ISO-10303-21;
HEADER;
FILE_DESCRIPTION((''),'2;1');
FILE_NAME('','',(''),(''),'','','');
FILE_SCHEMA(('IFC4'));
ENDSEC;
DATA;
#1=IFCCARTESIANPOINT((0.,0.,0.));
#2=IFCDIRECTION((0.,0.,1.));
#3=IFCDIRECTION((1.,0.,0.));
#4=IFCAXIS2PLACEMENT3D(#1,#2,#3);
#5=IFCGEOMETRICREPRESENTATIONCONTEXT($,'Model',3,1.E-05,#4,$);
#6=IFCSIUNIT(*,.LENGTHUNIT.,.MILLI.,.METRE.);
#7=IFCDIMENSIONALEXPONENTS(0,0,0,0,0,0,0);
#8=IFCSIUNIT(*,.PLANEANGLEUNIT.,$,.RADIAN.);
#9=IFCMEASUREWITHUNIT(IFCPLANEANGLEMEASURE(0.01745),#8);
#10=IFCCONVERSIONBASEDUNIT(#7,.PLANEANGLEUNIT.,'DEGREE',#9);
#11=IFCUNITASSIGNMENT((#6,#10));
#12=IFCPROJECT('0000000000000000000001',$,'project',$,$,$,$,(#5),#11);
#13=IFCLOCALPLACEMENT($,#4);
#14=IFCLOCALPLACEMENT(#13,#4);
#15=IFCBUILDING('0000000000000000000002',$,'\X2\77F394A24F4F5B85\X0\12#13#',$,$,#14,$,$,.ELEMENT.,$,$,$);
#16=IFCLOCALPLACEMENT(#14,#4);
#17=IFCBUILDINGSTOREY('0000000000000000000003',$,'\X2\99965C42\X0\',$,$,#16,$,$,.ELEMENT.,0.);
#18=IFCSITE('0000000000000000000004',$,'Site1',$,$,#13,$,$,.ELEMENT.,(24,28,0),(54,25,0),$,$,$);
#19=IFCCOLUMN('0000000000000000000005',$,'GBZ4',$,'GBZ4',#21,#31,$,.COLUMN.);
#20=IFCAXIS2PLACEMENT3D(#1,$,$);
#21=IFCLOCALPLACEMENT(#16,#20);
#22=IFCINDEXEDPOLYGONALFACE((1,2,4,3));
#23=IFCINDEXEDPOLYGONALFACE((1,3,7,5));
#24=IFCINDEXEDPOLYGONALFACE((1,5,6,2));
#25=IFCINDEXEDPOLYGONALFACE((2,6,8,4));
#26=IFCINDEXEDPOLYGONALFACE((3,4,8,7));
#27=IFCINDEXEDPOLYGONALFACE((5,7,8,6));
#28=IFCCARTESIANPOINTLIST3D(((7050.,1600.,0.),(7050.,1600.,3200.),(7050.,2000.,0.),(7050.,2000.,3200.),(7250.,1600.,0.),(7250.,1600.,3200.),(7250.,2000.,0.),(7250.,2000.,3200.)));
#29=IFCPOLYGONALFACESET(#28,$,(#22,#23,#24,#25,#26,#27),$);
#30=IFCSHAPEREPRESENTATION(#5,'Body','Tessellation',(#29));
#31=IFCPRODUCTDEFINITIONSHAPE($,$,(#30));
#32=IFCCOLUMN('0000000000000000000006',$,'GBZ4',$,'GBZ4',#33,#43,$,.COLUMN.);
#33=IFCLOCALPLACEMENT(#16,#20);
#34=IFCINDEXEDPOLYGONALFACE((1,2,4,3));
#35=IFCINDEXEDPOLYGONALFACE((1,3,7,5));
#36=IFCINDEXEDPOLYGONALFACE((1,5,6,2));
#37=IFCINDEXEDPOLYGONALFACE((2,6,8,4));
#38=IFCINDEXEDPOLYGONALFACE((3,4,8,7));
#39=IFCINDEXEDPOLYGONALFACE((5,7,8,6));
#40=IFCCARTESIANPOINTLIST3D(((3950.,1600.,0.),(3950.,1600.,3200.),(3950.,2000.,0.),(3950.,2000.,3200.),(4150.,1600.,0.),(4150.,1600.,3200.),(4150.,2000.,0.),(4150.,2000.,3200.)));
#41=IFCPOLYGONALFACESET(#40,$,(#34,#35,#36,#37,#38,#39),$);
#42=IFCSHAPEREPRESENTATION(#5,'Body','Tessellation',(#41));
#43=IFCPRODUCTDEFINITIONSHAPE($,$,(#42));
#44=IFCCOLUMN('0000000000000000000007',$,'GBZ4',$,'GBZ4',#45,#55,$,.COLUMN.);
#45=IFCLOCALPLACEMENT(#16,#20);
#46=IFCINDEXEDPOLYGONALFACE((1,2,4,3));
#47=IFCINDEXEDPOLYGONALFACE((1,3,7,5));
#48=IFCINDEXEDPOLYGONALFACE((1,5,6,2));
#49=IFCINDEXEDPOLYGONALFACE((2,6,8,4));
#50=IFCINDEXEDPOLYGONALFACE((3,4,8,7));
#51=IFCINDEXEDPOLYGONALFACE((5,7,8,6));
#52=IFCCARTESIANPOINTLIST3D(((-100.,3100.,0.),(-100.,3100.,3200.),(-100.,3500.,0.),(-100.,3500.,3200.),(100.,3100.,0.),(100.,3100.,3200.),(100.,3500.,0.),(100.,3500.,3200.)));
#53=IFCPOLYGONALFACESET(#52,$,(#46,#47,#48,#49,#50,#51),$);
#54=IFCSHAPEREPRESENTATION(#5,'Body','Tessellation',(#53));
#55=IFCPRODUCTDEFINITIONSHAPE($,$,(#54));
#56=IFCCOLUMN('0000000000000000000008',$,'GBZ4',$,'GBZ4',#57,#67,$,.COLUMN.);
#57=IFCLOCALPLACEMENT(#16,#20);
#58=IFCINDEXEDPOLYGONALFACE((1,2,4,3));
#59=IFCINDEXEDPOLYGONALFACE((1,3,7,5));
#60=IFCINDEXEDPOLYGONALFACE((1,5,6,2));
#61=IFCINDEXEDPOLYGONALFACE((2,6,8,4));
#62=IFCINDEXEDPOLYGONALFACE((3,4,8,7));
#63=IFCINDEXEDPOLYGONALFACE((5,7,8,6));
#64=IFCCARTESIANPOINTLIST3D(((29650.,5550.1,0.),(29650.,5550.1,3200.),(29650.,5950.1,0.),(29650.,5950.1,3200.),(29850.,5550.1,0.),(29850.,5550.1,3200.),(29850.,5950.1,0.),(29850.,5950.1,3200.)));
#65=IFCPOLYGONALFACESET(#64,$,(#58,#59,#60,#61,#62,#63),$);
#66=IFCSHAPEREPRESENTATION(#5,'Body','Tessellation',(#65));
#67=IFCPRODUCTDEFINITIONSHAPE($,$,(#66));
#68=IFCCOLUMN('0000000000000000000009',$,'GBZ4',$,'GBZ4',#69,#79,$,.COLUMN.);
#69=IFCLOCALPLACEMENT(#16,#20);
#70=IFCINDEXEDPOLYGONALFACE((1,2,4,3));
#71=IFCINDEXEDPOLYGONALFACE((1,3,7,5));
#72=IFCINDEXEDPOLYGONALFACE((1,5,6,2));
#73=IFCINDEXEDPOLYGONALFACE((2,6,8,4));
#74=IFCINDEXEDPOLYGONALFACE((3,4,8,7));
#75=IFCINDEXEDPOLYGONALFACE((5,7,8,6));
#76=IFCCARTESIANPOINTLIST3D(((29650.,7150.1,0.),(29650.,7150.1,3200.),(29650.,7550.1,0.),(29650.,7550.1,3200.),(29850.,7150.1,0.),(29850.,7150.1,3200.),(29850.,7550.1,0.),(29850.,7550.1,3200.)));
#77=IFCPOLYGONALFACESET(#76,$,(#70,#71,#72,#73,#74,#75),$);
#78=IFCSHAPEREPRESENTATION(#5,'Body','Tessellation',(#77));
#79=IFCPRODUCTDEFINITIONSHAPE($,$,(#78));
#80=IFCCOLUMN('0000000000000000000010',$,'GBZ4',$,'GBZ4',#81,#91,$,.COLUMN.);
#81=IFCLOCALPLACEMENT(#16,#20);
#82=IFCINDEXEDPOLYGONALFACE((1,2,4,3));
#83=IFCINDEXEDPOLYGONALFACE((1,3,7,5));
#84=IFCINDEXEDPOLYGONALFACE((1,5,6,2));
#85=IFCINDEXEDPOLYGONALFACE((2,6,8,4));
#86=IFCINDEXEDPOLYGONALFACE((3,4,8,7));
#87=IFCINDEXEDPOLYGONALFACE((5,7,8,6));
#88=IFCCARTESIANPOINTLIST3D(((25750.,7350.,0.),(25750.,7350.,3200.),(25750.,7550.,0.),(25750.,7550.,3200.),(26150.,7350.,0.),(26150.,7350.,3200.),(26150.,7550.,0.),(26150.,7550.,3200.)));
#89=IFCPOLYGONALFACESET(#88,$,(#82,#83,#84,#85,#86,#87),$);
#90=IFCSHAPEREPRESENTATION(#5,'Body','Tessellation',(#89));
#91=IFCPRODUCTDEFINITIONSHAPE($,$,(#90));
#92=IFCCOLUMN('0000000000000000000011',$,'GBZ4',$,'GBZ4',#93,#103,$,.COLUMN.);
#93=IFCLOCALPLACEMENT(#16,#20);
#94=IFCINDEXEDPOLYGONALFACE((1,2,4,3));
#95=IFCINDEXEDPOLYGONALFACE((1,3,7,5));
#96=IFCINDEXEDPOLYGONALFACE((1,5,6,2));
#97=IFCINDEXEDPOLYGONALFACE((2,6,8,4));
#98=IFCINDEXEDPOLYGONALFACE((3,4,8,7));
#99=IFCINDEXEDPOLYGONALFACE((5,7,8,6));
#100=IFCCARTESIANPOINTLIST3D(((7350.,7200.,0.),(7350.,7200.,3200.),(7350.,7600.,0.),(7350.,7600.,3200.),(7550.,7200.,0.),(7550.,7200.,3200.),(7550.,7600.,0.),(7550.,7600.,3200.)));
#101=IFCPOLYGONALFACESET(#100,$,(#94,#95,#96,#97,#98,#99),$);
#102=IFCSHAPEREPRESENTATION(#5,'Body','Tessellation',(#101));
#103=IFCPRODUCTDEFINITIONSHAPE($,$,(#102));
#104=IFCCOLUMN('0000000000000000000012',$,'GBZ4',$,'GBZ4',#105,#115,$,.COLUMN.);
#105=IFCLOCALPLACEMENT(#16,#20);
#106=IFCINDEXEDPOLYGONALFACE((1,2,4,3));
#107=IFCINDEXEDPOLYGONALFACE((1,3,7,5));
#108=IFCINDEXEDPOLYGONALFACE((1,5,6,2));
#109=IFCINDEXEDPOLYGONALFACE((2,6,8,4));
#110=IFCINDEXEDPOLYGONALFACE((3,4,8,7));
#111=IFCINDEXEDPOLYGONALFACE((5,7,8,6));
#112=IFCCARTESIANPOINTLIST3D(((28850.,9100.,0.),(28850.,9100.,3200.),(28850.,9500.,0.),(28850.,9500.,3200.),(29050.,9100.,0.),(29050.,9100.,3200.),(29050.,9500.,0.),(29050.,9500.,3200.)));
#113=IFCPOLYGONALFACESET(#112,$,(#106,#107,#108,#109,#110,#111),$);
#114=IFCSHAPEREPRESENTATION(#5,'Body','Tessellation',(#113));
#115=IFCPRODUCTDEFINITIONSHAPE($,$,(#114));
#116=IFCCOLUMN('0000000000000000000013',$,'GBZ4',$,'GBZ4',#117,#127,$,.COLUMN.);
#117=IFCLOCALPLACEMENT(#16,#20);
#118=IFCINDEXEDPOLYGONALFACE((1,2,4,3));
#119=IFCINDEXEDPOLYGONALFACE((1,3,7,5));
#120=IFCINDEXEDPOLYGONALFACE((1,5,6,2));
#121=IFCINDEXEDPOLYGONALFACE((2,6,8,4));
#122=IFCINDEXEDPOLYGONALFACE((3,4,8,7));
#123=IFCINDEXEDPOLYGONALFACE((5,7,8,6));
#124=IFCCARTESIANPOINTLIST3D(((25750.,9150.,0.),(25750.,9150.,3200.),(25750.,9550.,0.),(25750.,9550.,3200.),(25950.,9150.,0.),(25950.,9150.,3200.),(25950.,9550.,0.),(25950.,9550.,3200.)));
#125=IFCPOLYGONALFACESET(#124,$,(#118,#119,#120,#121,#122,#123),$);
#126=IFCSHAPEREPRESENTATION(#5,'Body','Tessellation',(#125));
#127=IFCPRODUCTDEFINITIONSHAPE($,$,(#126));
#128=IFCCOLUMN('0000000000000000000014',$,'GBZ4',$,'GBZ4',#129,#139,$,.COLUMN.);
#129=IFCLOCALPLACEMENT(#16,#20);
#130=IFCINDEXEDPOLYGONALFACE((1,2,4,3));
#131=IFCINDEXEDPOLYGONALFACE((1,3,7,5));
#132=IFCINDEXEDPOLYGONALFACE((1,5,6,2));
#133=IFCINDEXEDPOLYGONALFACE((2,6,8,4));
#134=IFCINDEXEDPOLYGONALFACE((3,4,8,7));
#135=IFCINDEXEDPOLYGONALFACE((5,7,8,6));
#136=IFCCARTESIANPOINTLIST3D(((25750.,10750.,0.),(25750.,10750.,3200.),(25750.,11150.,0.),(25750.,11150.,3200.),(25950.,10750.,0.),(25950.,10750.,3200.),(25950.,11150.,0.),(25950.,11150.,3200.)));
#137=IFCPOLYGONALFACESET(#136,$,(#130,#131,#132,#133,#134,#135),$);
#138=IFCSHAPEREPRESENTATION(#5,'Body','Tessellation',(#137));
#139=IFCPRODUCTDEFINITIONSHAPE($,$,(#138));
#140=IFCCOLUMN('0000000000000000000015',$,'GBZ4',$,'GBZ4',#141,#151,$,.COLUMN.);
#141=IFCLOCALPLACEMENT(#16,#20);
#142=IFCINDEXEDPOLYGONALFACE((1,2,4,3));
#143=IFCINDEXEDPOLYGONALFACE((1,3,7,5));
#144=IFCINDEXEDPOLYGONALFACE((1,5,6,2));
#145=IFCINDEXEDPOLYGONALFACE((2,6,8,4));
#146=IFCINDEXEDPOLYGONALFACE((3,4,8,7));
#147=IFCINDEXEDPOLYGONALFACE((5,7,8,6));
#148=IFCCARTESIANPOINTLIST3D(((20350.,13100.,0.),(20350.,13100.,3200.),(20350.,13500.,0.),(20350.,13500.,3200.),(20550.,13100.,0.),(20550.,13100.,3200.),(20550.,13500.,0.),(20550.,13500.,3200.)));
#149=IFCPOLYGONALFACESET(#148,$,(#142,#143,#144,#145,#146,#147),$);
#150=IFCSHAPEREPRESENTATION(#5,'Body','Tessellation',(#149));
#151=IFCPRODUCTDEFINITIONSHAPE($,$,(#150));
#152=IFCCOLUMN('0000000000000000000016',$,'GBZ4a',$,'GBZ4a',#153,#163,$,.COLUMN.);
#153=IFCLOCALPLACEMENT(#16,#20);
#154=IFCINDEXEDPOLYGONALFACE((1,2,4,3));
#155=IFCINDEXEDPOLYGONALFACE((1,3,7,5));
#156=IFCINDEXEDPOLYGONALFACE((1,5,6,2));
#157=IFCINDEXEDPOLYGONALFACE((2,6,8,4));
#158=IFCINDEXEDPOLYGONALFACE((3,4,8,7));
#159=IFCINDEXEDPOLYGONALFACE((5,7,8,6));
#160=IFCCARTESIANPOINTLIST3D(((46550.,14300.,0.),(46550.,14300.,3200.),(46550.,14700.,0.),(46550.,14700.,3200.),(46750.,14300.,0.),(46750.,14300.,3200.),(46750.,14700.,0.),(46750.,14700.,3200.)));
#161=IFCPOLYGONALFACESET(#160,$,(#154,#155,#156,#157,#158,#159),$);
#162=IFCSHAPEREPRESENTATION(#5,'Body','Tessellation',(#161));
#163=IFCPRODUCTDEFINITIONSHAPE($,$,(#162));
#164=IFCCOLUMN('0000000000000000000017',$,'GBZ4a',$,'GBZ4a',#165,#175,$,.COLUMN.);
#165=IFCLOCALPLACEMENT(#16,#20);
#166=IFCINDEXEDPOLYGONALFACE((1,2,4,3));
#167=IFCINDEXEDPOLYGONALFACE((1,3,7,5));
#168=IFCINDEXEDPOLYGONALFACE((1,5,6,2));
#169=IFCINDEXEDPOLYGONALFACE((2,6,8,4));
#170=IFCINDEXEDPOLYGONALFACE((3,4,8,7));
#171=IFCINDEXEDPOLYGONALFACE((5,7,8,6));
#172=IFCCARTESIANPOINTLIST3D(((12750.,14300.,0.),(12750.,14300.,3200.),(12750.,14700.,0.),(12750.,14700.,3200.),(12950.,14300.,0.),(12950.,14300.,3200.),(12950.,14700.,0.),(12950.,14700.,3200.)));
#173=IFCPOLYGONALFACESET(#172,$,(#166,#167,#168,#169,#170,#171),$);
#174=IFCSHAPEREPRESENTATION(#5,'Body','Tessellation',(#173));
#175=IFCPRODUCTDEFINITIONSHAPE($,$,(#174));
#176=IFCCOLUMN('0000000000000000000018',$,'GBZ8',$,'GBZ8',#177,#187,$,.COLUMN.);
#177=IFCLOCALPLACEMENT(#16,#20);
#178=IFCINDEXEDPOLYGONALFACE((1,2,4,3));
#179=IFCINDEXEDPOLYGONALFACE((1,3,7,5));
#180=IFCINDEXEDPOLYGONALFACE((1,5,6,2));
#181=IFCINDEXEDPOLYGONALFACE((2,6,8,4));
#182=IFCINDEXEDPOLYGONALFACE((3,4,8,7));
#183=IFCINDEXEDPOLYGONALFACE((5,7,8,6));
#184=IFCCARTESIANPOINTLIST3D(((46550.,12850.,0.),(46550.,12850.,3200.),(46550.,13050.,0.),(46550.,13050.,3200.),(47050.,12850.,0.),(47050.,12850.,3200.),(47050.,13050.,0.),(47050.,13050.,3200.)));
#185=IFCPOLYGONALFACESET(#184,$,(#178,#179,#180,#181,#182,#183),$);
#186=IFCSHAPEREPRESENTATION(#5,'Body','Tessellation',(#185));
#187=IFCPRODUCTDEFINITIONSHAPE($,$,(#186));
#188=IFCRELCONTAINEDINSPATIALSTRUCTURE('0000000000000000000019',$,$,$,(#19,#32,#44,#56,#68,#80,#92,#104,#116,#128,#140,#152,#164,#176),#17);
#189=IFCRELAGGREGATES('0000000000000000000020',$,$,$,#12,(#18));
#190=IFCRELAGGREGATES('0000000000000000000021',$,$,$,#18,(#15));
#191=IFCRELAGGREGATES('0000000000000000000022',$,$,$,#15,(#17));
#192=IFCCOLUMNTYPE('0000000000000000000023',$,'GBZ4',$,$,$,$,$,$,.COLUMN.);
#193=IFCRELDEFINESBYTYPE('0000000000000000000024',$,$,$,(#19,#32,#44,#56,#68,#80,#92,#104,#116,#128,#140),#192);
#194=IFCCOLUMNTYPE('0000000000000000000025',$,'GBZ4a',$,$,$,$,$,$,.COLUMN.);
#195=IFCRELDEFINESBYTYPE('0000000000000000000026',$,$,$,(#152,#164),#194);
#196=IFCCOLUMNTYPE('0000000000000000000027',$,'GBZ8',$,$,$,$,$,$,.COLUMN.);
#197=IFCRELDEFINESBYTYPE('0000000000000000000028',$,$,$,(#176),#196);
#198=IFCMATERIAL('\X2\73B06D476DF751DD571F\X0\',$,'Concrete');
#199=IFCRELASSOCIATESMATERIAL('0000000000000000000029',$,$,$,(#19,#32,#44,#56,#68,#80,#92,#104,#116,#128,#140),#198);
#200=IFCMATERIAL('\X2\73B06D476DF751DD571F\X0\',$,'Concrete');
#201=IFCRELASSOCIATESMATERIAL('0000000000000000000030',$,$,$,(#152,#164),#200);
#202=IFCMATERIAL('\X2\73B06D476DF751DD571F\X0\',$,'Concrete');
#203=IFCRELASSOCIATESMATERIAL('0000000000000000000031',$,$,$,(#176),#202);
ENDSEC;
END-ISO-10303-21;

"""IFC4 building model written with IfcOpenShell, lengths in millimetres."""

from ifc_helpers import new_model, entity, si_unit, converted_unit, frame, origin_with_axes, place, context, project, spatial, polyline, outline, extrude, material, type_object, element, save


model = new_model("IFC4")

# Units and contexts
model_context = context("Model", 3, precision=1e-05, world=origin_with_axes())
ifc_project = project(units=[si_unit("LENGTHUNIT", "METRE", prefix="MILLI"), converted_unit("PLANEANGLEUNIT", "DEGREE", entity("IfcPlaneAngleMeasure", 0.01745), si_unit("PLANEANGLEUNIT", "RADIAN"), dimensions=[0, 0, 0, 0, 0, 0, 0])], contexts=[model_context])

# Site, building, storey
site_placement = place(None, origin_with_axes())
site = spatial("IfcSite", under=ifc_project, at=site_placement, Name="Site1", CompositionType="ELEMENT", RefLatitude=(24, 28, 0), RefLongitude=(54, 25, 0))
building_placement = place(site_placement, origin_with_axes())
building = spatial("IfcBuilding", under=site, at=building_placement, Name="石钢住宅12#13#", CompositionType="ELEMENT")
storey_placement = place(building_placement, origin_with_axes())
storey = spatial("IfcBuildingStorey", under=building, at=storey_placement, Name="首层", CompositionType="ELEMENT", Elevation=0.0)

# Columns
ifc_material_1 = material(Name="现浇混凝土", Category="Concrete")
column_type_1 = type_object("IfcColumnType", Name="GBZ4", PredefinedType="COLUMN")
column_1_placement = place(storey_placement, origin_with_axes())
element("IfcColumn", 1, at=column_1_placement, inside=storey, type_object=column_type_1, material=ifc_material_1, Name="GBZ4", ObjectType="GBZ4", PredefinedType="COLUMN", context=model_context, shape_type="SweptSolid", body=[
    extrude(outline(polyline([(0.0, 0.0), (200.0, 0.0), (200.0, 400.0), (0.0, 400.0), (0.0, 0.0)])), frame((7050.0, 1600.0, 0.0), z_axis=(0.0, 0.0, 1.0), x_axis=(1.0, 0.0, 0.0)), (0.0, 0.0, 1.0), 3200.0),
])
column_2_placement = place(storey_placement, origin_with_axes())
element("IfcColumn", 2, at=column_2_placement, inside=storey, type_object=column_type_1, material=ifc_material_1, Name="GBZ4", ObjectType="GBZ4", PredefinedType="COLUMN", context=model_context, shape_type="SweptSolid", body=[
    extrude(outline(polyline([(0.0, 0.0), (200.0, 0.0), (200.0, 400.0), (0.0, 400.0), (0.0, 0.0)])), frame((3950.0, 1600.0, 0.0), z_axis=(0.0, 0.0, 1.0), x_axis=(1.0, 0.0, 0.0)), (0.0, 0.0, 1.0), 3200.0),
])
column_3_placement = place(storey_placement, origin_with_axes())
element("IfcColumn", 3, at=column_3_placement, inside=storey, type_object=column_type_1, material=ifc_material_1, Name="GBZ4", ObjectType="GBZ4", PredefinedType="COLUMN", context=model_context, shape_type="SweptSolid", body=[
    extrude(outline(polyline([(0.0, 0.0), (200.0, 0.0), (200.0, 400.0), (0.0, 400.0), (0.0, 0.0)])), frame((-100.0, 3100.0, 0.0), z_axis=(0.0, 0.0, 1.0), x_axis=(1.0, 0.0, 0.0)), (0.0, 0.0, 1.0), 3200.0),
])
column_4_placement = place(storey_placement, origin_with_axes())
element("IfcColumn", 4, at=column_4_placement, inside=storey, type_object=column_type_1, material=ifc_material_1, Name="GBZ4", ObjectType="GBZ4", PredefinedType="COLUMN", context=model_context, shape_type="SweptSolid", body=[
    extrude(outline(polyline([(0.0, 0.0), (200.0, 0.0), (200.0, 400.0), (0.0, 400.0), (0.0, 0.0)])), frame((29650.0, 5550.1, 0.0), z_axis=(0.0, 0.0, 1.0), x_axis=(1.0, 0.0, 0.0)), (0.0, 0.0, 1.0), 3200.0),
])
column_5_placement = place(storey_placement, origin_with_axes())
element("IfcColumn", 5, at=column_5_placement, inside=storey, type_object=column_type_1, material=ifc_material_1, Name="GBZ4", ObjectType="GBZ4", PredefinedType="COLUMN", context=model_context, shape_type="SweptSolid", body=[
    extrude(outline(polyline([(0.0, 0.0), (200.0, 0.0), (200.0, 400.0), (0.0, 400.0), (0.0, 0.0)])), frame((29650.0, 7150.1, 0.0), z_axis=(0.0, 0.0, 1.0), x_axis=(1.0, 0.0, 0.0)), (0.0, 0.0, 1.0), 3200.0),
])
column_6_placement = place(storey_placement, origin_with_axes())
element("IfcColumn", 6, at=column_6_placement, inside=storey, type_object=column_type_1, material=ifc_material_1, Name="GBZ4", ObjectType="GBZ4", PredefinedType="COLUMN", context=model_context, shape_type="SweptSolid", body=[
    extrude(outline(polyline([(0.0, 0.0), (200.0, 0.0), (200.0, 400.0), (0.0, 400.0), (0.0, 0.0)])), frame((26150.0, 7350.0, 0.0), z_axis=(0.0, 0.0, 1.0), x_axis=(0.0, 1.0, 0.0)), (0.0, 0.0, 1.0), 3200.0),
])
column_7_placement = place(storey_placement, origin_with_axes())
element("IfcColumn", 7, at=column_7_placement, inside=storey, type_object=column_type_1, material=ifc_material_1, Name="GBZ4", ObjectType="GBZ4", PredefinedType="COLUMN", context=model_context, shape_type="SweptSolid", body=[
    extrude(outline(polyline([(0.0, 0.0), (200.0, 0.0), (200.0, 400.0), (0.0, 400.0), (0.0, 0.0)])), frame((7350.0, 7200.0, 0.0), z_axis=(0.0, 0.0, 1.0), x_axis=(1.0, 0.0, 0.0)), (0.0, 0.0, 1.0), 3200.0),
])
column_8_placement = place(storey_placement, origin_with_axes())
element("IfcColumn", 8, at=column_8_placement, inside=storey, type_object=column_type_1, material=ifc_material_1, Name="GBZ4", ObjectType="GBZ4", PredefinedType="COLUMN", context=model_context, shape_type="SweptSolid", body=[
    extrude(outline(polyline([(0.0, 0.0), (200.0, 0.0), (200.0, 400.0), (0.0, 400.0), (0.0, 0.0)])), frame((28850.0, 9100.0, 0.0), z_axis=(0.0, 0.0, 1.0), x_axis=(1.0, 0.0, 0.0)), (0.0, 0.0, 1.0), 3200.0),
])
column_9_placement = place(storey_placement, origin_with_axes())
element("IfcColumn", 9, at=column_9_placement, inside=storey, type_object=column_type_1, material=ifc_material_1, Name="GBZ4", ObjectType="GBZ4", PredefinedType="COLUMN", context=model_context, shape_type="SweptSolid", body=[
    extrude(outline(polyline([(0.0, 0.0), (200.0, 0.0), (200.0, 400.0), (0.0, 400.0), (0.0, 0.0)])), frame((25750.0, 9150.0, 0.0), z_axis=(0.0, 0.0, 1.0), x_axis=(1.0, 0.0, 0.0)), (0.0, 0.0, 1.0), 3200.0),
])
column_10_placement = place(storey_placement, origin_with_axes())
element("IfcColumn", 10, at=column_10_placement, inside=storey, type_object=column_type_1, material=ifc_material_1, Name="GBZ4", ObjectType="GBZ4", PredefinedType="COLUMN", context=model_context, shape_type="SweptSolid", body=[
    extrude(outline(polyline([(0.0, 0.0), (200.0, 0.0), (200.0, 400.0), (0.0, 400.0), (0.0, 0.0)])), frame((25750.0, 10750.0, 0.0), z_axis=(0.0, 0.0, 1.0), x_axis=(1.0, 0.0, 0.0)), (0.0, 0.0, 1.0), 3200.0),
])
column_11_placement = place(storey_placement, origin_with_axes())
element("IfcColumn", 11, at=column_11_placement, inside=storey, type_object=column_type_1, material=ifc_material_1, Name="GBZ4", ObjectType="GBZ4", PredefinedType="COLUMN", context=model_context, shape_type="SweptSolid", body=[
    extrude(outline(polyline([(0.0, 0.0), (200.0, 0.0), (200.0, 400.0), (0.0, 400.0), (0.0, 0.0)])), frame((20350.0, 13100.0, 0.0), z_axis=(0.0, 0.0, 1.0), x_axis=(1.0, 0.0, 0.0)), (0.0, 0.0, 1.0), 3200.0),
])
ifc_material_2 = material(Name="现浇混凝土", Category="Concrete")
column_type_2 = type_object("IfcColumnType", Name="GBZ4a", PredefinedType="COLUMN")
column_12_placement = place(storey_placement, origin_with_axes())
element("IfcColumn", 12, at=column_12_placement, inside=storey, type_object=column_type_2, material=ifc_material_2, Name="GBZ4a", ObjectType="GBZ4a", PredefinedType="COLUMN", context=model_context, shape_type="SweptSolid", body=[
    extrude(outline(polyline([(0.0, 0.0), (400.0, 0.0), (400.0, 200.0), (0.0, 200.0), (0.0, 0.0)])), frame((46750.0, 14300.0, 0.0), z_axis=(0.0, 0.0, 1.0), x_axis=(0.0, 1.0, 0.0)), (0.0, 0.0, 1.0), 3200.0),
])
column_13_placement = place(storey_placement, origin_with_axes())
element("IfcColumn", 13, at=column_13_placement, inside=storey, type_object=column_type_2, material=ifc_material_2, Name="GBZ4a", ObjectType="GBZ4a", PredefinedType="COLUMN", context=model_context, shape_type="SweptSolid", body=[
    extrude(outline(polyline([(0.0, 0.0), (200.0, 0.0), (200.0, 400.0), (0.0, 400.0), (0.0, 0.0)])), frame((12750.0, 14300.0, 0.0), z_axis=(0.0, 0.0, 1.0), x_axis=(1.0, 0.0, 0.0)), (0.0, 0.0, 1.0), 3200.0),
])
ifc_material_3 = material(Name="现浇混凝土", Category="Concrete")
column_type_3 = type_object("IfcColumnType", Name="GBZ8", PredefinedType="COLUMN")
column_14_placement = place(storey_placement, origin_with_axes())
element("IfcColumn", 14, at=column_14_placement, inside=storey, type_object=column_type_3, material=ifc_material_3, Name="GBZ8", ObjectType="GBZ8", PredefinedType="COLUMN", context=model_context, shape_type="SweptSolid", body=[
    extrude(outline(polyline([(0.0, 0.0), (500.0, 0.0), (500.0, 200.0), (0.0, 200.0), (0.0, 0.0)])), frame((46550.0, 12850.0, 0.0), z_axis=(0.0, 0.0, 1.0), x_axis=(1.0, 0.0, 0.0)), (0.0, 0.0, 1.0), 3200.0),
])

save(model, "model.ifc")
